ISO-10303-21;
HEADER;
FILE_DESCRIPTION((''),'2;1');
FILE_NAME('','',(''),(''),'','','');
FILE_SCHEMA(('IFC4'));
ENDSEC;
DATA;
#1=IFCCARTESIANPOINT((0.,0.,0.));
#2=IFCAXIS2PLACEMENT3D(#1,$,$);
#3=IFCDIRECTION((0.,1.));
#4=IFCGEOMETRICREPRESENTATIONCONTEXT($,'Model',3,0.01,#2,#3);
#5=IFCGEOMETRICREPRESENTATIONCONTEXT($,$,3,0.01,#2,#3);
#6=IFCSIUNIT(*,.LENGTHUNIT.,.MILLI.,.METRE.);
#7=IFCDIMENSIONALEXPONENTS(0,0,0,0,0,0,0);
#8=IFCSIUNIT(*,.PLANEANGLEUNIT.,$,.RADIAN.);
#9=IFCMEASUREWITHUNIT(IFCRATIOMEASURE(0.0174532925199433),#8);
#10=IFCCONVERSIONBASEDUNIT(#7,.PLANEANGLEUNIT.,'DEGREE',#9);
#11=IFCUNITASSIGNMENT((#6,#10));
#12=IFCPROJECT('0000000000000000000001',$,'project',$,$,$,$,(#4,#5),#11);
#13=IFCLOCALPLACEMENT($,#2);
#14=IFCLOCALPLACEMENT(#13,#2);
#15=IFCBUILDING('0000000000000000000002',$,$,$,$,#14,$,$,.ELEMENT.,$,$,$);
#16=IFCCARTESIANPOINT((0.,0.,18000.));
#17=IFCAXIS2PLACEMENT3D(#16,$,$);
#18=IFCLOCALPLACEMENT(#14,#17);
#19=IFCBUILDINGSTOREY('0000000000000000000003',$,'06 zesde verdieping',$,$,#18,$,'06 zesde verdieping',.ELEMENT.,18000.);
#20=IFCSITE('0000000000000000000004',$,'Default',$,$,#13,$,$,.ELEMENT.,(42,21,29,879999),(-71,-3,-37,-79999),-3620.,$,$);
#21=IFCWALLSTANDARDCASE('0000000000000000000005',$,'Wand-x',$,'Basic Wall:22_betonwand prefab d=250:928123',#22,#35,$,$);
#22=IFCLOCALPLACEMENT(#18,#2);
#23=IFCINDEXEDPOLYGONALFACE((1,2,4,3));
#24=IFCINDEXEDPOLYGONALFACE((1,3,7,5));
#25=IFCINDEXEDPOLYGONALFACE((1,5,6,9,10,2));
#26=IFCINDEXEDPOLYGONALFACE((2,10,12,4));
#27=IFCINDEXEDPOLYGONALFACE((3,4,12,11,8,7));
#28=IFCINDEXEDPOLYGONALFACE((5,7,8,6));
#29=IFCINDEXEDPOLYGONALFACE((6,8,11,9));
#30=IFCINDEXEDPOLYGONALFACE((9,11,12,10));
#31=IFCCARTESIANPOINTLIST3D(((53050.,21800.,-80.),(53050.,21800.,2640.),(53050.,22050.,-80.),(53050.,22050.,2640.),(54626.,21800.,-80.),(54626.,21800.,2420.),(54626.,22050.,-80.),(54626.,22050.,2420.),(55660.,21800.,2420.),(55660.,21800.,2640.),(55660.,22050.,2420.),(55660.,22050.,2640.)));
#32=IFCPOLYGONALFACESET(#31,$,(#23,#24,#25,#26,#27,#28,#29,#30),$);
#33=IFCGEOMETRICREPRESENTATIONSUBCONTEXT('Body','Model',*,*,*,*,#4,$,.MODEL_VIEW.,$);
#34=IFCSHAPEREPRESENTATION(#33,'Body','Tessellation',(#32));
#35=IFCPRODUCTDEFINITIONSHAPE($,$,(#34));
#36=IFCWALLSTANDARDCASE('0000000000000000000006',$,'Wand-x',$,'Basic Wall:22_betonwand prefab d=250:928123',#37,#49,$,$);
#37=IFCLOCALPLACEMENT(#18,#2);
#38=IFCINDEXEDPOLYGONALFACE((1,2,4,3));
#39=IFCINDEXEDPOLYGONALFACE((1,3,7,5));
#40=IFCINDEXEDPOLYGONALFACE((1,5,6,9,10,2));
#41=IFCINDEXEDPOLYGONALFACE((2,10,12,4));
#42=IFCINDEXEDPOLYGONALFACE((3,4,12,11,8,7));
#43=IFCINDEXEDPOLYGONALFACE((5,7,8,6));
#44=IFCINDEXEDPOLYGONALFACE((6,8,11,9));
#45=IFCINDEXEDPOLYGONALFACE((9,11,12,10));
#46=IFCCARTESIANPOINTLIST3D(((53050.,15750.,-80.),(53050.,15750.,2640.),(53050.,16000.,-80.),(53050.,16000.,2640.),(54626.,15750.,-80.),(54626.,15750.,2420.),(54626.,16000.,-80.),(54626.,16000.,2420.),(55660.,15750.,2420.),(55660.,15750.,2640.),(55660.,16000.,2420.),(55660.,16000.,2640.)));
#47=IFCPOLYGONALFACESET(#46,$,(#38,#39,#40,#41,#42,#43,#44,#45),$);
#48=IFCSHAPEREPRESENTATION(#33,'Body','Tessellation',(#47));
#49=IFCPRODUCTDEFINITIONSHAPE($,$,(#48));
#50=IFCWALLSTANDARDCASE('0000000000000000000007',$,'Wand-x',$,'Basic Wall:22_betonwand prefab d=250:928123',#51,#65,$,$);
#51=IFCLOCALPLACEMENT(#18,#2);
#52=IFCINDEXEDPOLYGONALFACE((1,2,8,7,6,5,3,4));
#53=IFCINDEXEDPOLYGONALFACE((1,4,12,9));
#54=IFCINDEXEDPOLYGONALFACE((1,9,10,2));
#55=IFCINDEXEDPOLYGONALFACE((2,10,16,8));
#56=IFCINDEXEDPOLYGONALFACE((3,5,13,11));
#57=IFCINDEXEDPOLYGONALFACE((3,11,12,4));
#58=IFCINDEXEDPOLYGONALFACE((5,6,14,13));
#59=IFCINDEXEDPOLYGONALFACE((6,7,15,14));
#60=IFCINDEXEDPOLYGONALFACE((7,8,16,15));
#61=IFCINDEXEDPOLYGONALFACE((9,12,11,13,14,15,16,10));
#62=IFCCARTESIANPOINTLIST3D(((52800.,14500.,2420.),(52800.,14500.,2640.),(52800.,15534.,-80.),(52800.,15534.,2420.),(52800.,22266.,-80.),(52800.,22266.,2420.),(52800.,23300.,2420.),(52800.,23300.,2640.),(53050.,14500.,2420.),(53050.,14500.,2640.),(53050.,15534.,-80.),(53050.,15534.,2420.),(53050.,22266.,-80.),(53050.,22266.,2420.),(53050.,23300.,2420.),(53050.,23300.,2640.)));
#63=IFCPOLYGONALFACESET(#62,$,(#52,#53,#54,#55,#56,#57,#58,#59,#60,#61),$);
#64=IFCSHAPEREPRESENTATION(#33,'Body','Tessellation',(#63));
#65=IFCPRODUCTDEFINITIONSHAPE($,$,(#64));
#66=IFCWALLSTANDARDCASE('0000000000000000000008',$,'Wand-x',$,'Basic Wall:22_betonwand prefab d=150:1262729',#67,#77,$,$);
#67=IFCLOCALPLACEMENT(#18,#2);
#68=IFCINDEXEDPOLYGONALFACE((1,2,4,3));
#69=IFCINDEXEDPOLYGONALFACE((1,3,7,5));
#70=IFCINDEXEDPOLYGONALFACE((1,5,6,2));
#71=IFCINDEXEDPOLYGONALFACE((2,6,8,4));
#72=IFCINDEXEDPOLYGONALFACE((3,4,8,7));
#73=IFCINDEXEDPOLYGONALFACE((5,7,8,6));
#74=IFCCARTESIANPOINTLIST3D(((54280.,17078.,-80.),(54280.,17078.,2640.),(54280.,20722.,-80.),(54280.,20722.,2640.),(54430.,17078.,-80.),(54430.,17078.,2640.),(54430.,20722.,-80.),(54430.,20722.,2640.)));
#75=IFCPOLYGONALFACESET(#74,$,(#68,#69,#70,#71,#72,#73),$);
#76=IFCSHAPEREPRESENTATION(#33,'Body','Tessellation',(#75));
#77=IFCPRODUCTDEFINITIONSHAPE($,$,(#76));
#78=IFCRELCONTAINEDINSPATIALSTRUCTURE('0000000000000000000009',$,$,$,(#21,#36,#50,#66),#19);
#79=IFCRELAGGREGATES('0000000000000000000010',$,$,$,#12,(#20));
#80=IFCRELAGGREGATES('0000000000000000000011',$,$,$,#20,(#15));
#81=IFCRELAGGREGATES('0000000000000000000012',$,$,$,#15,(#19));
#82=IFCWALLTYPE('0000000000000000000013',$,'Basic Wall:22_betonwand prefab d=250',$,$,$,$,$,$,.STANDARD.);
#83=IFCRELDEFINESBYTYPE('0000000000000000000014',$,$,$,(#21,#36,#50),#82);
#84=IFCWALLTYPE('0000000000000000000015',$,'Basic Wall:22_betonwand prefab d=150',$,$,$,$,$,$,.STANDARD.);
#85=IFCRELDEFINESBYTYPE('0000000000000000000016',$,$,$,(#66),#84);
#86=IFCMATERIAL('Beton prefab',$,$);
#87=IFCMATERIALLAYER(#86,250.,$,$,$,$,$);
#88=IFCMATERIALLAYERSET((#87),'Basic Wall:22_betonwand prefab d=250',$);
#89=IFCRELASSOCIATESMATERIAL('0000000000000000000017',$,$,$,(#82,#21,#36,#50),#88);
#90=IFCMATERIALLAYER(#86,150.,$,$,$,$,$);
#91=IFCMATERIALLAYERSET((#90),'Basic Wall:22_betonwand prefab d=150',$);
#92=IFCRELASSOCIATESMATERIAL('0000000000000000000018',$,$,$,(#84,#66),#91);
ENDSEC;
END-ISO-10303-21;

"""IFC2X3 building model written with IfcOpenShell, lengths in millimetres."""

from ifc_helpers import new_model, entity, si_unit, converted_unit, direction, frame, frame_2d, origin, place, context, subcontext, project, spatial, rectangle, extrude, material, layer, layer_set, layer_usage, type_object, element, save


model = new_model("IFC2X3")

# Units and contexts
model_context = context("Model", 3, precision=0.01, world=origin(), true_north=direction((0.0, 1.0)))
context_of_model = context(None, 3, precision=0.01, world=origin(), true_north=direction((0.0, 1.0)))
body_context = subcontext(model_context, "Body", "Model", "MODEL_VIEW")
ifc_project = project(units=[si_unit("LENGTHUNIT", "METRE", prefix="MILLI"), converted_unit("PLANEANGLEUNIT", "DEGREE", entity("IfcRatioMeasure", 0.0174532925199433), si_unit("PLANEANGLEUNIT", "RADIAN"), dimensions=[0, 0, 0, 0, 0, 0, 0])], contexts=[model_context, context_of_model])

# Site, building, storey
site_placement = place(None, origin())
site = spatial("IfcSite", under=ifc_project, at=site_placement, Name="Default", CompositionType="ELEMENT", RefLatitude=(42, 21, 29, 879999), RefLongitude=(-71, -3, -37, -79999), RefElevation=-3620.0)
building_placement = place(site_placement, origin())
building = spatial("IfcBuilding", under=site, at=building_placement, CompositionType="ELEMENT")
storey_placement = place(building_placement, frame((0.0, 0.0, 18000.0)))
storey = spatial("IfcBuildingStorey", under=building, at=storey_placement, Name="06 zesde verdieping", LongName="06 zesde verdieping", CompositionType="ELEMENT", Elevation=18000.0)

# Shared definitions
ifc_material_1 = material(Name="Beton prefab")

# Walls, openings
ifc_layer_1 = layer(ifc_material_1, 250.0)
ifc_layer_set_1 = layer_set([ifc_layer_1], Name="Basic Wall:22_betonwand prefab d=250")
ifc_layer_usage_1 = layer_usage(ifc_layer_set_1, "AXIS2", "NEGATIVE", 125.0)
wall_type_1 = type_object("IfcWallType", Name="Basic Wall:22_betonwand prefab d=250", PredefinedType="STANDARD", material=ifc_layer_set_1)
wall_1_placement = place(storey_placement, frame((53050.0, 21925.0, -80.0)))
wall_1 = element("IfcWallStandardCase", 1, at=wall_1_placement, inside=storey, type_object=wall_type_1, material=ifc_layer_usage_1, Name="Wand-x", ObjectType="Basic Wall:22_betonwand prefab d=250:928123", context=body_context, shape_type="SweptSolid", body=[
    extrude(rectangle(XDim=2610.0, YDim=250.0, at=frame_2d((1305.0, 0.0), x_axis=(-1.0, 0.0))), origin(), (0.0, 0.0, 1.0), 2720.0),
])
opening_1_placement = place(wall_1_placement, frame((-53050.0, -21925.0, 80.0)))
element("IfcOpeningElement", 2, at=opening_1_placement, cuts=wall_1, ObjectType="Opening", context=body_context, shape_type="SweptSolid", body=[
    extrude(rectangle(XDim=2500.0, YDim=1034.0, at=frame_2d((0.0, 0.0), x_axis=(1.0, 0.0))), frame((55143.0, 21525.0, 1170.0), z_axis=(0.0, 1.0, 0.0), x_axis=(0.0, 0.0, -1.0)), (0.0, 0.0, 1.0), 800.0),
])
ifc_layer_usage_2 = layer_usage(ifc_layer_set_1, "AXIS2", "POSITIVE", -125.0)
wall_2_placement = place(storey_placement, frame((53050.0, 15875.0, -80.0)))
wall_2 = element("IfcWallStandardCase", 3, at=wall_2_placement, inside=storey, type_object=wall_type_1, material=ifc_layer_usage_2, Name="Wand-x", ObjectType="Basic Wall:22_betonwand prefab d=250:928123", context=body_context, shape_type="SweptSolid", body=[
    extrude(rectangle(XDim=2610.0, YDim=250.0, at=frame_2d((1305.0, 0.0), x_axis=(-1.0, 0.0))), origin(), (0.0, 0.0, 1.0), 2720.0),
])
opening_2_placement = place(wall_2_placement, frame((-53050.0, -15875.0, 80.0)))
element("IfcOpeningElement", 4, at=opening_2_placement, cuts=wall_2, ObjectType="Opening", context=body_context, shape_type="SweptSolid", body=[
    extrude(rectangle(XDim=2500.0, YDim=1034.0, at=frame_2d((0.0, 0.0), x_axis=(1.0, 0.0))), frame((55143.0, 15475.0, 1170.0), z_axis=(0.0, 1.0, 0.0), x_axis=(0.0, 0.0, -1.0)), (0.0, 0.0, 1.0), 800.0),
])

# Wall, openings
ifc_layer_usage_3 = layer_usage(ifc_layer_set_1, "AXIS2", "NEGATIVE", 125.0)
wall_3_placement = place(storey_placement, frame((52925.0, 14500.0, -80.0), z_axis=(0.0, 0.0, 1.0), x_axis=(0.0, 1.0, 0.0)))
wall_3 = element("IfcWallStandardCase", 5, at=wall_3_placement, inside=storey, type_object=wall_type_1, material=ifc_layer_usage_3, Name="Wand-x", ObjectType="Basic Wall:22_betonwand prefab d=250:928123", context=body_context, shape_type="SweptSolid", body=[
    extrude(rectangle(XDim=8800.0, YDim=250.0, at=frame_2d((4400.0, 0.0), x_axis=(-1.0, 0.0))), origin(), (0.0, 0.0, 1.0), 2720.0),
])
opening_3_placement = place(wall_3_placement, frame((-14500.0, 52925.0, 80.0), z_axis=(0.0, 0.0, 1.0), x_axis=(0.0, -1.0, 0.0)))
element("IfcOpeningElement", 6, at=opening_3_placement, cuts=wall_3, ObjectType="Opening", context=body_context, shape_type="SweptSolid", body=[
    extrude(rectangle(XDim=2500.0, YDim=1034.0, at=frame_2d((0.0, 0.0), x_axis=(1.0, 0.0))), frame((53325.0, 15017.0, 1170.0), z_axis=(-1.0, 0.0, 0.0), x_axis=(0.0, 0.0, -1.0)), (0.0, 0.0, 1.0), 800.0),
])
opening_4_placement = place(wall_3_placement, frame((-14500.0, 52925.0, 80.0), z_axis=(0.0, 0.0, 1.0), x_axis=(0.0, -1.0, 0.0)))
element("IfcOpeningElement", 7, at=opening_4_placement, cuts=wall_3, ObjectType="Opening", context=body_context, shape_type="SweptSolid", body=[
    extrude(rectangle(XDim=2500.0, YDim=1034.0, at=frame_2d((0.0, 0.0), x_axis=(0.0, 1.0))), frame((53325.0, 22783.0, 1170.0), z_axis=(-1.0, 0.0, 0.0), x_axis=(0.0, 1.0, 0.0)), (0.0, 0.0, 1.0), 800.0),
])

# Wall
ifc_layer_2 = layer(ifc_material_1, 150.0)
ifc_layer_set_2 = layer_set([ifc_layer_2], Name="Basic Wall:22_betonwand prefab d=150")
ifc_layer_usage_4 = layer_usage(ifc_layer_set_2, "AXIS2", "NEGATIVE", 75.0)
wall_type_2 = type_object("IfcWallType", Name="Basic Wall:22_betonwand prefab d=150", PredefinedType="STANDARD", material=ifc_layer_set_2)
wall_4_placement = place(storey_placement, frame((54355.0, 17078.0, -80.0), z_axis=(0.0, 0.0, 1.0), x_axis=(0.0, 1.0, 0.0)))
element("IfcWallStandardCase", 8, at=wall_4_placement, inside=storey, type_object=wall_type_2, material=ifc_layer_usage_4, Name="Wand-x", ObjectType="Basic Wall:22_betonwand prefab d=150:1262729", context=body_context, shape_type="SweptSolid", body=[
    extrude(rectangle(XDim=3644.0, YDim=150.0, at=frame_2d((1822.0, 0.0), x_axis=(-1.0, 0.0))), origin(), (0.0, 0.0, 1.0), 2720.0),
])

save(model, "model.ifc")
